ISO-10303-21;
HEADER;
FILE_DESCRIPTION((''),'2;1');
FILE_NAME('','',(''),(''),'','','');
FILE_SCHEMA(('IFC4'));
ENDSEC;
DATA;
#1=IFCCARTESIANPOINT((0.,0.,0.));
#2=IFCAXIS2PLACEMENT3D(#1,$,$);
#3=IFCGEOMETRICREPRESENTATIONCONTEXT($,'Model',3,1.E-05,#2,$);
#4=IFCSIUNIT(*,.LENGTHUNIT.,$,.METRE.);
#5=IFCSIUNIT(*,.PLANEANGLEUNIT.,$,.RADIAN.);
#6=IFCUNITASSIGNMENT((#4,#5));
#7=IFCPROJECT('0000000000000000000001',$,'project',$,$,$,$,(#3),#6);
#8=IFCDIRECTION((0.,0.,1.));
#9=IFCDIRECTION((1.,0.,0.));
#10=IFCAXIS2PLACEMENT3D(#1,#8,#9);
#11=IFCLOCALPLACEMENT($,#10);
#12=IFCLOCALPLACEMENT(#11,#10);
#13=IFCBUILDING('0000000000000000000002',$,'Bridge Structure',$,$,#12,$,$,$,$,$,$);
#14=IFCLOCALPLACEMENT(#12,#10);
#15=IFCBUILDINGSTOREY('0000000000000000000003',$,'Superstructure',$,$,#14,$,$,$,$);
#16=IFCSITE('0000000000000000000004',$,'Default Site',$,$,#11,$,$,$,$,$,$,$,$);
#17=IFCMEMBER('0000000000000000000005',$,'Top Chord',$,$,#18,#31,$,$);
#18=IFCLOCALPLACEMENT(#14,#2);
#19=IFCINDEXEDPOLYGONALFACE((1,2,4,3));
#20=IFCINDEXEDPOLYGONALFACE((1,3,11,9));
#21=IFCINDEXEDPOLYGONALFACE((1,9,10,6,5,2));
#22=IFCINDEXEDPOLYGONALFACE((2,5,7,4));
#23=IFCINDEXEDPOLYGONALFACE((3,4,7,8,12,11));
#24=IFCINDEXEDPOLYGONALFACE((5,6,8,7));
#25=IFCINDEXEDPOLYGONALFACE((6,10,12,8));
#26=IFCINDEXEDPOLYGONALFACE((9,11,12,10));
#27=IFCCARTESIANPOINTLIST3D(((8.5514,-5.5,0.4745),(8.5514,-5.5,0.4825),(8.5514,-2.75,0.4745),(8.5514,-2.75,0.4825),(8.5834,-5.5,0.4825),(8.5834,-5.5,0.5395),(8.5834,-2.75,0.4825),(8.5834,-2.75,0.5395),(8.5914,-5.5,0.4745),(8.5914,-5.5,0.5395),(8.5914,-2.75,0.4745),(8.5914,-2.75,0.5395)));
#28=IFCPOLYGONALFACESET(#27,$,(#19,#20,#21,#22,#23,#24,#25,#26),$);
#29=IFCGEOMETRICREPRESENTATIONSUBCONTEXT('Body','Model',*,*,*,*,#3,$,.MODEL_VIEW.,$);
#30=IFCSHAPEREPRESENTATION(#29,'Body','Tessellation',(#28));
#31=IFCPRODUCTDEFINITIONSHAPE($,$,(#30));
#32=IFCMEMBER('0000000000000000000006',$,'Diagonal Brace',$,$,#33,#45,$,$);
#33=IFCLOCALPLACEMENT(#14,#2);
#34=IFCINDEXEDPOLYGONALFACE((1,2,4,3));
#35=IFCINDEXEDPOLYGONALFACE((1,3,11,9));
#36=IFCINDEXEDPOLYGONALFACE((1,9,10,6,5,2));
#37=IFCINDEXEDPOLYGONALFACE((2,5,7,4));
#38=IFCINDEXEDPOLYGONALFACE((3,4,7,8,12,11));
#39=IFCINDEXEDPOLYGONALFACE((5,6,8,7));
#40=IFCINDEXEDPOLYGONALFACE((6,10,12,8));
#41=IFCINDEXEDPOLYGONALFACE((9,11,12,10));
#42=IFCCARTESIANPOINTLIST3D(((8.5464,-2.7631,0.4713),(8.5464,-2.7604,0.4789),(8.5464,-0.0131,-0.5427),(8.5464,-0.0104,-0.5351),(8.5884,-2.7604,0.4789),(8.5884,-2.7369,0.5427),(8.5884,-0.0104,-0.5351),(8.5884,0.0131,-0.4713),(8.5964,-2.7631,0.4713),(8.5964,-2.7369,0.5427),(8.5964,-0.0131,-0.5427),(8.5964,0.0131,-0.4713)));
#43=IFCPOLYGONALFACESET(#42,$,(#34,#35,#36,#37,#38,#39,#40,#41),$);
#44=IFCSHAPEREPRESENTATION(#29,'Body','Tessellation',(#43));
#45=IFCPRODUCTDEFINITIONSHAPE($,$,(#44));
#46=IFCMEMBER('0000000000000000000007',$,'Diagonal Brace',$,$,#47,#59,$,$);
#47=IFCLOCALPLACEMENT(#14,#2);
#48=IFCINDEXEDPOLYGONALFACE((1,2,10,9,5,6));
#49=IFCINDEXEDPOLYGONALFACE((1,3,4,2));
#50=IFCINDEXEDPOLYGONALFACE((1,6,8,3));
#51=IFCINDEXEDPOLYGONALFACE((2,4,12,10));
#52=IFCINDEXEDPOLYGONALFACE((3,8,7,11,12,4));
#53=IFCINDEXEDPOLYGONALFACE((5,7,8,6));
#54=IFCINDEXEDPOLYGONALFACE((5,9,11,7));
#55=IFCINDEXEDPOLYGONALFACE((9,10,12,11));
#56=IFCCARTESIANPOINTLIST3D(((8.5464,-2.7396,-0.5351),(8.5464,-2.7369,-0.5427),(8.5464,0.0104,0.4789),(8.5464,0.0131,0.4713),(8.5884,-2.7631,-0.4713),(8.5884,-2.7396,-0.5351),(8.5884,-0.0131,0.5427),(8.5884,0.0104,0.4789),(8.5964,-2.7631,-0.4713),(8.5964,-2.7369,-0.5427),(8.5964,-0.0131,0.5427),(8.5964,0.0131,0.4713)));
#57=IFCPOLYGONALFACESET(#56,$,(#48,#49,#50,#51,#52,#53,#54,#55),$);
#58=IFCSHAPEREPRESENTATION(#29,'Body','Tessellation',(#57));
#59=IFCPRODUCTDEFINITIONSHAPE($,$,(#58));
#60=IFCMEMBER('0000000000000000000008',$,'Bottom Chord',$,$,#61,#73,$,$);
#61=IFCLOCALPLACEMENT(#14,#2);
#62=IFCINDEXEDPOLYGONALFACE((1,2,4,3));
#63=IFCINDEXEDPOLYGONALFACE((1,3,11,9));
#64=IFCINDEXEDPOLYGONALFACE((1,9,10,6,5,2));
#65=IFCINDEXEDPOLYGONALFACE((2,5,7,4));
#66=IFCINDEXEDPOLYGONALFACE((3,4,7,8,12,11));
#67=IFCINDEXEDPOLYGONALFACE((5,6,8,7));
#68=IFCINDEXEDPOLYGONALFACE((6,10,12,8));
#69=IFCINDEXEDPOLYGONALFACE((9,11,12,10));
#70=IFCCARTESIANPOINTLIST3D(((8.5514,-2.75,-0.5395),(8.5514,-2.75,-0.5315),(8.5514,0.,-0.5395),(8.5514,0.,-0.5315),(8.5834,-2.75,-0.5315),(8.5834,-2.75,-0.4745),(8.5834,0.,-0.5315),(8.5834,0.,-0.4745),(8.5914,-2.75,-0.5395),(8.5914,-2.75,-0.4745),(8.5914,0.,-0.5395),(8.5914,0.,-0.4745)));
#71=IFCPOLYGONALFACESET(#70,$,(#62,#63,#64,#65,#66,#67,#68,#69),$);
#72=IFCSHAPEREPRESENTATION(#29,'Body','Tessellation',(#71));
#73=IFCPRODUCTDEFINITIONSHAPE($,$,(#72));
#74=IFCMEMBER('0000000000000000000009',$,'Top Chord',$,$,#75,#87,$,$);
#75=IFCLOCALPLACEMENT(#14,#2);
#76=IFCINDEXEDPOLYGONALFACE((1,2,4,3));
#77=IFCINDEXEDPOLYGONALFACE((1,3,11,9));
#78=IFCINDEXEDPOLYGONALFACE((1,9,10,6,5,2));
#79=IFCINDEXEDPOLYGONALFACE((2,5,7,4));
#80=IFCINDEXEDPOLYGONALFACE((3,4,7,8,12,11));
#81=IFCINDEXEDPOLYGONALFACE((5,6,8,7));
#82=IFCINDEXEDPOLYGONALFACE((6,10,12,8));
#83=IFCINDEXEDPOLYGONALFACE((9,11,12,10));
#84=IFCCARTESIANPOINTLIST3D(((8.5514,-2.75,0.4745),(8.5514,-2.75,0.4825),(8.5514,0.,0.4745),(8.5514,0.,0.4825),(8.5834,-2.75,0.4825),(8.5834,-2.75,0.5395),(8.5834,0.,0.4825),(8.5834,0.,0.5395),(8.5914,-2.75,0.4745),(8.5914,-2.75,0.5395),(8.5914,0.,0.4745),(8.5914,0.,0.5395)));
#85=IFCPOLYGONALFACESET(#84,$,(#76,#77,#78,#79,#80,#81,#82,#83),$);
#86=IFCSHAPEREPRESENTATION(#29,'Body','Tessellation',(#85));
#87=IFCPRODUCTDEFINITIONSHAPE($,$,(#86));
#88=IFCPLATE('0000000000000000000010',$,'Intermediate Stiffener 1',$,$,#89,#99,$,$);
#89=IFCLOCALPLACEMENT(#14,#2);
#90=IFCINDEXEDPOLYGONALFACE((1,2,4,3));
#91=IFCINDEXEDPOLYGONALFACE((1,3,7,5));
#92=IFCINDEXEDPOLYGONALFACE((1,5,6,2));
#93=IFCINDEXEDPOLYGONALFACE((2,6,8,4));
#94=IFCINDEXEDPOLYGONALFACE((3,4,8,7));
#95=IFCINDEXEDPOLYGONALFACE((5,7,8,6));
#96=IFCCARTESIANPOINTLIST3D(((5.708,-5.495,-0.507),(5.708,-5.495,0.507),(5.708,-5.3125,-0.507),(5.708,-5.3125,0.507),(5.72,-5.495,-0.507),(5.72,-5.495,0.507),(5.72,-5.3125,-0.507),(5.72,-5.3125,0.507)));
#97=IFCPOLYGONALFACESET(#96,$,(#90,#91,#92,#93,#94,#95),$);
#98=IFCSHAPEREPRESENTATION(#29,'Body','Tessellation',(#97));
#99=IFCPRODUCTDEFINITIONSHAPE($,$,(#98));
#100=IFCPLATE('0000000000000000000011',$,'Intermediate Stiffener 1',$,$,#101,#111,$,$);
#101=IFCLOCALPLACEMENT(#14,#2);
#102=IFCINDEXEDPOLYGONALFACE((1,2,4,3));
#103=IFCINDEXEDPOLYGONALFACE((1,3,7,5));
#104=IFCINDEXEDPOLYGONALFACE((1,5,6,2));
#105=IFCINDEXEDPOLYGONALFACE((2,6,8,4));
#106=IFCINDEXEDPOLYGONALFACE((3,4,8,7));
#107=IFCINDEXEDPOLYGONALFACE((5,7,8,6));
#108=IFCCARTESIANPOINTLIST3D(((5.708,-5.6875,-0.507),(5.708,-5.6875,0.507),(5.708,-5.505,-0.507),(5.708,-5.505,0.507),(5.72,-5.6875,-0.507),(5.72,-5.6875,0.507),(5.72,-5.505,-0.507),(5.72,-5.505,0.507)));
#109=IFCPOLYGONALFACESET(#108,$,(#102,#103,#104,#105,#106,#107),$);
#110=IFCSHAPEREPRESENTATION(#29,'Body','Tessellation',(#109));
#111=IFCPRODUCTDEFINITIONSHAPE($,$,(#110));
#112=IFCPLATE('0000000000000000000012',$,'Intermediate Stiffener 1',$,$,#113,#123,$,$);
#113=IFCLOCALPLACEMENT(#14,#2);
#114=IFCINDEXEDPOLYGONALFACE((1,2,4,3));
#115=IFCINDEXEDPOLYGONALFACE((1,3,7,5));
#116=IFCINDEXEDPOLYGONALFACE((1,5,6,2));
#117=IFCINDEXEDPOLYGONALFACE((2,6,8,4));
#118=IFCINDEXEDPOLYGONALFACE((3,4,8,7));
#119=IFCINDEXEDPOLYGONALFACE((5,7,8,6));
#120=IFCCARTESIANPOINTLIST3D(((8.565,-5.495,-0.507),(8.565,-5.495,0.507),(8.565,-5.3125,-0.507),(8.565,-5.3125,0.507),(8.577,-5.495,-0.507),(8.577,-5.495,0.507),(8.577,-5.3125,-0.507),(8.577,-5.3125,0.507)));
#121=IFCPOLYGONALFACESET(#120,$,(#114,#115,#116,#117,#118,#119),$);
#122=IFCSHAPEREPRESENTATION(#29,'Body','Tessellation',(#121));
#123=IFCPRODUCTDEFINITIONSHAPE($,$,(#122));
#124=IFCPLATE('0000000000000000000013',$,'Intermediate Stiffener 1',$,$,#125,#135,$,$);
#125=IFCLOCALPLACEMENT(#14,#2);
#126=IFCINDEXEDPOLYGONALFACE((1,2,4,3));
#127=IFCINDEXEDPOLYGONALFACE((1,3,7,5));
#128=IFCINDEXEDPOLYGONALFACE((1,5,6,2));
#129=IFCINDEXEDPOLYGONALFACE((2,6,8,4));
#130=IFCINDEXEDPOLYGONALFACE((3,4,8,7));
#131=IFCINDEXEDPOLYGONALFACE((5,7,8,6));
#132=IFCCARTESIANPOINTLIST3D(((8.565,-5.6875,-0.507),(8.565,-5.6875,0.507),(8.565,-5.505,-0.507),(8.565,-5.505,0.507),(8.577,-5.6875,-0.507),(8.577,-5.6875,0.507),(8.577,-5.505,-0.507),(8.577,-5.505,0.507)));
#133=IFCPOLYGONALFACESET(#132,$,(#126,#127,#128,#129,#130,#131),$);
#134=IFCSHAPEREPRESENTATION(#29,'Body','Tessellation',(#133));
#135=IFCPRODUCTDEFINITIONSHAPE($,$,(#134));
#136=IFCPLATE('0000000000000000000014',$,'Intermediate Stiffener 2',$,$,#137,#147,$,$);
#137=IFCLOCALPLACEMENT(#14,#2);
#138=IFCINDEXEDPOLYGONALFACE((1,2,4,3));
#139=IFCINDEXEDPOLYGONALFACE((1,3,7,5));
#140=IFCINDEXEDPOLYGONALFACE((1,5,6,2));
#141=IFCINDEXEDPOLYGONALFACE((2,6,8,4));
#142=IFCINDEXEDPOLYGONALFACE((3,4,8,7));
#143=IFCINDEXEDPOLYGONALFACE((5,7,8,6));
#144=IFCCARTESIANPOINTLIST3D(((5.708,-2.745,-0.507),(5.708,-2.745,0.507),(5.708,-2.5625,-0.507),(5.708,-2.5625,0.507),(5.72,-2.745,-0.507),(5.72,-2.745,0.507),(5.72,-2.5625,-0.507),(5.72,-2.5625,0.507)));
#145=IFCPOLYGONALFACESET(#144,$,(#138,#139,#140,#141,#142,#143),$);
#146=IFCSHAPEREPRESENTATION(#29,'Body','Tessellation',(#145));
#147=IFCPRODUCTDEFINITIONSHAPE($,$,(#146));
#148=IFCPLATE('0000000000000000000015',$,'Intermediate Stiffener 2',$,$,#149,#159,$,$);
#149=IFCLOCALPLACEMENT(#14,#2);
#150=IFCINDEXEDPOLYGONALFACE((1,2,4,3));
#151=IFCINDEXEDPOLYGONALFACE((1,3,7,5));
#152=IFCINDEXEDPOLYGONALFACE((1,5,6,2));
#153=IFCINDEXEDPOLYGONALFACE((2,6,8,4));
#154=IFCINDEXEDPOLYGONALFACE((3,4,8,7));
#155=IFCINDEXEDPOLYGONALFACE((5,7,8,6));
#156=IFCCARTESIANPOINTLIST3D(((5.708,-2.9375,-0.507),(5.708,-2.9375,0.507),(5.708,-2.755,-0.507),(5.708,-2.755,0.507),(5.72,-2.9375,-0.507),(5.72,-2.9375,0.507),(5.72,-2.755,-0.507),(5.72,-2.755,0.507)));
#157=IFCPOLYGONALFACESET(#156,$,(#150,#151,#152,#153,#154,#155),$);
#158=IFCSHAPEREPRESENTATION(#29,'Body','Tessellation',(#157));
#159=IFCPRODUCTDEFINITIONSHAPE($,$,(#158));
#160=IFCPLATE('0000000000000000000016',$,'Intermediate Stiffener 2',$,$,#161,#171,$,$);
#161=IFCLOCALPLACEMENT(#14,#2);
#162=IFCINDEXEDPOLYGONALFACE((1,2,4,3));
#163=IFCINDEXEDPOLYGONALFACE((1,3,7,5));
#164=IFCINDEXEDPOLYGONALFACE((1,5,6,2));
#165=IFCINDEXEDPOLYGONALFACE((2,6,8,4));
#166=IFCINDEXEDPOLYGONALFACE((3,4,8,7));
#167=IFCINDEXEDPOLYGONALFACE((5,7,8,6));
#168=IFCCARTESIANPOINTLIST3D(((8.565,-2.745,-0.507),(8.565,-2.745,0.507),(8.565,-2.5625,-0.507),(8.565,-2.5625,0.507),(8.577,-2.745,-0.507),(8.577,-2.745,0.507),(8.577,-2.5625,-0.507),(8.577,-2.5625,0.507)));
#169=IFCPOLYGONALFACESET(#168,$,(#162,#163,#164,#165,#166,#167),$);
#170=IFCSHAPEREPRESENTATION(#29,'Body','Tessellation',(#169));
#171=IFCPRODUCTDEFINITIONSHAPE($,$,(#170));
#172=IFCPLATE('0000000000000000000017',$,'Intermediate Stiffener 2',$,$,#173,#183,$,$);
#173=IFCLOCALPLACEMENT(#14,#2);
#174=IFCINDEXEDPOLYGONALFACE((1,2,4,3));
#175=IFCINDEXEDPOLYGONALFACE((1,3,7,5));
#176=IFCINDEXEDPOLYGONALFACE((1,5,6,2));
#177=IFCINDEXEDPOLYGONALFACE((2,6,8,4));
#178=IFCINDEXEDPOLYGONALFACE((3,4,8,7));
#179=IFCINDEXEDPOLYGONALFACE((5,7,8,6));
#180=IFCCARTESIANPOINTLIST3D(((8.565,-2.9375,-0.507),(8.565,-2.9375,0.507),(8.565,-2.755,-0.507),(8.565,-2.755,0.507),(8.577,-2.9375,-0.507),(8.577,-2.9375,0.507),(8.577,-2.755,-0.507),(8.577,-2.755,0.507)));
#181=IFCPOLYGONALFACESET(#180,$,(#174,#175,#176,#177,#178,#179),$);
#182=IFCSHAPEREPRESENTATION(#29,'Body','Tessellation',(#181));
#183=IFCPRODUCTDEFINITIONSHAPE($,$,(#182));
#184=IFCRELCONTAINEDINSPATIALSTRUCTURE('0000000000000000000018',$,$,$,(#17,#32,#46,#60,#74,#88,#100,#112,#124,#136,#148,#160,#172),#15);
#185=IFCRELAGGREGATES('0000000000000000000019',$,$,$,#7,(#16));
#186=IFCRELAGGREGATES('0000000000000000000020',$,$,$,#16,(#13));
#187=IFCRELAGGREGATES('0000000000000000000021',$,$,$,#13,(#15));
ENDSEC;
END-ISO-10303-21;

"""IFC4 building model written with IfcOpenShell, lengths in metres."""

from ifc_helpers import new_model, si_unit, frame, origin, origin_with_axes, origin_2d_with_axis, place, context, subcontext, project, spatial, rectangle, l_section, extrude, element, save


model = new_model("IFC4")

# Units and contexts
model_context = context("Model", 3, precision=1e-05, world=origin())
body_context = subcontext(model_context, "Body", "Model", "MODEL_VIEW")
ifc_project = project(units=[si_unit("LENGTHUNIT", "METRE"), si_unit("PLANEANGLEUNIT", "RADIAN")], contexts=[model_context])

# Site, building, storey
site_placement = place(None, origin_with_axes())
site = spatial("IfcSite", under=ifc_project, at=site_placement, Name="Default Site")
building_placement = place(site_placement, origin_with_axes())
building = spatial("IfcBuilding", under=site, at=building_placement, Name="Bridge Structure")
storey_placement = place(building_placement, origin_with_axes())
storey = spatial("IfcBuildingStorey", under=building, at=storey_placement, Name="Superstructure")

# Members
for number, where, z_axis, x_axis, name in (
    (1, (8.5714, -5.5, 0.507), (0.0, 1.0, 0.0), (-1.0, 0.0, 0.0), "Top Chord"),
):
    element("IfcMember", number, at=place(storey_placement, frame(where, z_axis=z_axis, x_axis=x_axis)), inside=storey, Name=name, context=body_context, shape_type="SweptSolid", body=[
        extrude(l_section(Depth=0.065, Width=0.04, Thickness=0.008, at=origin_2d_with_axis()), origin_with_axes(), (0.0, 0.0, 1.0), 2.75),
    ])
for number, where, z_axis, x_axis, name in (
    (2, (8.5714, -2.75, 0.507), (0.0, 0.93825, -0.345958), (-1.0, 0.0, 0.0), "Diagonal Brace"),
    (3, (8.5714, -2.75, -0.507), (0.0, 0.93825, 0.345958), (-1.0, 0.0, 0.0), "Diagonal Brace"),
):
    element("IfcMember", number, at=place(storey_placement, frame(where, z_axis=z_axis, x_axis=x_axis)), inside=storey, Name=name, context=body_context, shape_type="SweptSolid", body=[
        extrude(l_section(Depth=0.076, Width=0.05, Thickness=0.008, at=origin_2d_with_axis()), origin_with_axes(), (0.0, 0.0, 1.0), 2.931),
    ])
for number, where, z_axis, x_axis, name in (
    (4, (8.5714, -2.75, -0.507), (0.0, 1.0, 0.0), (-1.0, 0.0, 0.0), "Bottom Chord"),
    (5, (8.5714, -2.75, 0.507), (0.0, 1.0, 0.0), (-1.0, 0.0, 0.0), "Top Chord"),
):
    element("IfcMember", number, at=place(storey_placement, frame(where, z_axis=z_axis, x_axis=x_axis)), inside=storey, Name=name, context=body_context, shape_type="SweptSolid", body=[
        extrude(l_section(Depth=0.065, Width=0.04, Thickness=0.008, at=origin_2d_with_axis()), origin_with_axes(), (0.0, 0.0, 1.0), 2.75),
    ])

# Plates
for number, where, z_axis, x_axis, name in (
    (6, (5.714, -5.4038, -0.507), (0.0, 0.0, 1.0), (1.0, 0.0, 0.0), "Intermediate Stiffener 1"),
    (7, (5.714, -5.5963, -0.507), (0.0, 0.0, 1.0), (1.0, 0.0, 0.0), "Intermediate Stiffener 1"),
    (8, (8.571, -5.4038, -0.507), (0.0, 0.0, 1.0), (1.0, 0.0, 0.0), "Intermediate Stiffener 1"),
    (9, (8.571, -5.5963, -0.507), (0.0, 0.0, 1.0), (1.0, 0.0, 0.0), "Intermediate Stiffener 1"),
    (10, (5.714, -2.6538, -0.507), (0.0, 0.0, 1.0), (1.0, 0.0, 0.0), "Intermediate Stiffener 2"),
    (11, (5.714, -2.8462, -0.507), (0.0, 0.0, 1.0), (1.0, 0.0, 0.0), "Intermediate Stiffener 2"),
    (12, (8.571, -2.6538, -0.507), (0.0, 0.0, 1.0), (1.0, 0.0, 0.0), "Intermediate Stiffener 2"),
    (13, (8.571, -2.8462, -0.507), (0.0, 0.0, 1.0), (1.0, 0.0, 0.0), "Intermediate Stiffener 2"),
):
    element("IfcPlate", number, at=place(storey_placement, frame(where, z_axis=z_axis, x_axis=x_axis)), inside=storey, Name=name, context=body_context, shape_type="SweptSolid", body=[
        extrude(rectangle(XDim=0.012, YDim=0.1825, at=origin_2d_with_axis()), origin_with_axes(), (0.0, 0.0, 1.0), 1.014),
    ])

save(model, "model.ifc")
